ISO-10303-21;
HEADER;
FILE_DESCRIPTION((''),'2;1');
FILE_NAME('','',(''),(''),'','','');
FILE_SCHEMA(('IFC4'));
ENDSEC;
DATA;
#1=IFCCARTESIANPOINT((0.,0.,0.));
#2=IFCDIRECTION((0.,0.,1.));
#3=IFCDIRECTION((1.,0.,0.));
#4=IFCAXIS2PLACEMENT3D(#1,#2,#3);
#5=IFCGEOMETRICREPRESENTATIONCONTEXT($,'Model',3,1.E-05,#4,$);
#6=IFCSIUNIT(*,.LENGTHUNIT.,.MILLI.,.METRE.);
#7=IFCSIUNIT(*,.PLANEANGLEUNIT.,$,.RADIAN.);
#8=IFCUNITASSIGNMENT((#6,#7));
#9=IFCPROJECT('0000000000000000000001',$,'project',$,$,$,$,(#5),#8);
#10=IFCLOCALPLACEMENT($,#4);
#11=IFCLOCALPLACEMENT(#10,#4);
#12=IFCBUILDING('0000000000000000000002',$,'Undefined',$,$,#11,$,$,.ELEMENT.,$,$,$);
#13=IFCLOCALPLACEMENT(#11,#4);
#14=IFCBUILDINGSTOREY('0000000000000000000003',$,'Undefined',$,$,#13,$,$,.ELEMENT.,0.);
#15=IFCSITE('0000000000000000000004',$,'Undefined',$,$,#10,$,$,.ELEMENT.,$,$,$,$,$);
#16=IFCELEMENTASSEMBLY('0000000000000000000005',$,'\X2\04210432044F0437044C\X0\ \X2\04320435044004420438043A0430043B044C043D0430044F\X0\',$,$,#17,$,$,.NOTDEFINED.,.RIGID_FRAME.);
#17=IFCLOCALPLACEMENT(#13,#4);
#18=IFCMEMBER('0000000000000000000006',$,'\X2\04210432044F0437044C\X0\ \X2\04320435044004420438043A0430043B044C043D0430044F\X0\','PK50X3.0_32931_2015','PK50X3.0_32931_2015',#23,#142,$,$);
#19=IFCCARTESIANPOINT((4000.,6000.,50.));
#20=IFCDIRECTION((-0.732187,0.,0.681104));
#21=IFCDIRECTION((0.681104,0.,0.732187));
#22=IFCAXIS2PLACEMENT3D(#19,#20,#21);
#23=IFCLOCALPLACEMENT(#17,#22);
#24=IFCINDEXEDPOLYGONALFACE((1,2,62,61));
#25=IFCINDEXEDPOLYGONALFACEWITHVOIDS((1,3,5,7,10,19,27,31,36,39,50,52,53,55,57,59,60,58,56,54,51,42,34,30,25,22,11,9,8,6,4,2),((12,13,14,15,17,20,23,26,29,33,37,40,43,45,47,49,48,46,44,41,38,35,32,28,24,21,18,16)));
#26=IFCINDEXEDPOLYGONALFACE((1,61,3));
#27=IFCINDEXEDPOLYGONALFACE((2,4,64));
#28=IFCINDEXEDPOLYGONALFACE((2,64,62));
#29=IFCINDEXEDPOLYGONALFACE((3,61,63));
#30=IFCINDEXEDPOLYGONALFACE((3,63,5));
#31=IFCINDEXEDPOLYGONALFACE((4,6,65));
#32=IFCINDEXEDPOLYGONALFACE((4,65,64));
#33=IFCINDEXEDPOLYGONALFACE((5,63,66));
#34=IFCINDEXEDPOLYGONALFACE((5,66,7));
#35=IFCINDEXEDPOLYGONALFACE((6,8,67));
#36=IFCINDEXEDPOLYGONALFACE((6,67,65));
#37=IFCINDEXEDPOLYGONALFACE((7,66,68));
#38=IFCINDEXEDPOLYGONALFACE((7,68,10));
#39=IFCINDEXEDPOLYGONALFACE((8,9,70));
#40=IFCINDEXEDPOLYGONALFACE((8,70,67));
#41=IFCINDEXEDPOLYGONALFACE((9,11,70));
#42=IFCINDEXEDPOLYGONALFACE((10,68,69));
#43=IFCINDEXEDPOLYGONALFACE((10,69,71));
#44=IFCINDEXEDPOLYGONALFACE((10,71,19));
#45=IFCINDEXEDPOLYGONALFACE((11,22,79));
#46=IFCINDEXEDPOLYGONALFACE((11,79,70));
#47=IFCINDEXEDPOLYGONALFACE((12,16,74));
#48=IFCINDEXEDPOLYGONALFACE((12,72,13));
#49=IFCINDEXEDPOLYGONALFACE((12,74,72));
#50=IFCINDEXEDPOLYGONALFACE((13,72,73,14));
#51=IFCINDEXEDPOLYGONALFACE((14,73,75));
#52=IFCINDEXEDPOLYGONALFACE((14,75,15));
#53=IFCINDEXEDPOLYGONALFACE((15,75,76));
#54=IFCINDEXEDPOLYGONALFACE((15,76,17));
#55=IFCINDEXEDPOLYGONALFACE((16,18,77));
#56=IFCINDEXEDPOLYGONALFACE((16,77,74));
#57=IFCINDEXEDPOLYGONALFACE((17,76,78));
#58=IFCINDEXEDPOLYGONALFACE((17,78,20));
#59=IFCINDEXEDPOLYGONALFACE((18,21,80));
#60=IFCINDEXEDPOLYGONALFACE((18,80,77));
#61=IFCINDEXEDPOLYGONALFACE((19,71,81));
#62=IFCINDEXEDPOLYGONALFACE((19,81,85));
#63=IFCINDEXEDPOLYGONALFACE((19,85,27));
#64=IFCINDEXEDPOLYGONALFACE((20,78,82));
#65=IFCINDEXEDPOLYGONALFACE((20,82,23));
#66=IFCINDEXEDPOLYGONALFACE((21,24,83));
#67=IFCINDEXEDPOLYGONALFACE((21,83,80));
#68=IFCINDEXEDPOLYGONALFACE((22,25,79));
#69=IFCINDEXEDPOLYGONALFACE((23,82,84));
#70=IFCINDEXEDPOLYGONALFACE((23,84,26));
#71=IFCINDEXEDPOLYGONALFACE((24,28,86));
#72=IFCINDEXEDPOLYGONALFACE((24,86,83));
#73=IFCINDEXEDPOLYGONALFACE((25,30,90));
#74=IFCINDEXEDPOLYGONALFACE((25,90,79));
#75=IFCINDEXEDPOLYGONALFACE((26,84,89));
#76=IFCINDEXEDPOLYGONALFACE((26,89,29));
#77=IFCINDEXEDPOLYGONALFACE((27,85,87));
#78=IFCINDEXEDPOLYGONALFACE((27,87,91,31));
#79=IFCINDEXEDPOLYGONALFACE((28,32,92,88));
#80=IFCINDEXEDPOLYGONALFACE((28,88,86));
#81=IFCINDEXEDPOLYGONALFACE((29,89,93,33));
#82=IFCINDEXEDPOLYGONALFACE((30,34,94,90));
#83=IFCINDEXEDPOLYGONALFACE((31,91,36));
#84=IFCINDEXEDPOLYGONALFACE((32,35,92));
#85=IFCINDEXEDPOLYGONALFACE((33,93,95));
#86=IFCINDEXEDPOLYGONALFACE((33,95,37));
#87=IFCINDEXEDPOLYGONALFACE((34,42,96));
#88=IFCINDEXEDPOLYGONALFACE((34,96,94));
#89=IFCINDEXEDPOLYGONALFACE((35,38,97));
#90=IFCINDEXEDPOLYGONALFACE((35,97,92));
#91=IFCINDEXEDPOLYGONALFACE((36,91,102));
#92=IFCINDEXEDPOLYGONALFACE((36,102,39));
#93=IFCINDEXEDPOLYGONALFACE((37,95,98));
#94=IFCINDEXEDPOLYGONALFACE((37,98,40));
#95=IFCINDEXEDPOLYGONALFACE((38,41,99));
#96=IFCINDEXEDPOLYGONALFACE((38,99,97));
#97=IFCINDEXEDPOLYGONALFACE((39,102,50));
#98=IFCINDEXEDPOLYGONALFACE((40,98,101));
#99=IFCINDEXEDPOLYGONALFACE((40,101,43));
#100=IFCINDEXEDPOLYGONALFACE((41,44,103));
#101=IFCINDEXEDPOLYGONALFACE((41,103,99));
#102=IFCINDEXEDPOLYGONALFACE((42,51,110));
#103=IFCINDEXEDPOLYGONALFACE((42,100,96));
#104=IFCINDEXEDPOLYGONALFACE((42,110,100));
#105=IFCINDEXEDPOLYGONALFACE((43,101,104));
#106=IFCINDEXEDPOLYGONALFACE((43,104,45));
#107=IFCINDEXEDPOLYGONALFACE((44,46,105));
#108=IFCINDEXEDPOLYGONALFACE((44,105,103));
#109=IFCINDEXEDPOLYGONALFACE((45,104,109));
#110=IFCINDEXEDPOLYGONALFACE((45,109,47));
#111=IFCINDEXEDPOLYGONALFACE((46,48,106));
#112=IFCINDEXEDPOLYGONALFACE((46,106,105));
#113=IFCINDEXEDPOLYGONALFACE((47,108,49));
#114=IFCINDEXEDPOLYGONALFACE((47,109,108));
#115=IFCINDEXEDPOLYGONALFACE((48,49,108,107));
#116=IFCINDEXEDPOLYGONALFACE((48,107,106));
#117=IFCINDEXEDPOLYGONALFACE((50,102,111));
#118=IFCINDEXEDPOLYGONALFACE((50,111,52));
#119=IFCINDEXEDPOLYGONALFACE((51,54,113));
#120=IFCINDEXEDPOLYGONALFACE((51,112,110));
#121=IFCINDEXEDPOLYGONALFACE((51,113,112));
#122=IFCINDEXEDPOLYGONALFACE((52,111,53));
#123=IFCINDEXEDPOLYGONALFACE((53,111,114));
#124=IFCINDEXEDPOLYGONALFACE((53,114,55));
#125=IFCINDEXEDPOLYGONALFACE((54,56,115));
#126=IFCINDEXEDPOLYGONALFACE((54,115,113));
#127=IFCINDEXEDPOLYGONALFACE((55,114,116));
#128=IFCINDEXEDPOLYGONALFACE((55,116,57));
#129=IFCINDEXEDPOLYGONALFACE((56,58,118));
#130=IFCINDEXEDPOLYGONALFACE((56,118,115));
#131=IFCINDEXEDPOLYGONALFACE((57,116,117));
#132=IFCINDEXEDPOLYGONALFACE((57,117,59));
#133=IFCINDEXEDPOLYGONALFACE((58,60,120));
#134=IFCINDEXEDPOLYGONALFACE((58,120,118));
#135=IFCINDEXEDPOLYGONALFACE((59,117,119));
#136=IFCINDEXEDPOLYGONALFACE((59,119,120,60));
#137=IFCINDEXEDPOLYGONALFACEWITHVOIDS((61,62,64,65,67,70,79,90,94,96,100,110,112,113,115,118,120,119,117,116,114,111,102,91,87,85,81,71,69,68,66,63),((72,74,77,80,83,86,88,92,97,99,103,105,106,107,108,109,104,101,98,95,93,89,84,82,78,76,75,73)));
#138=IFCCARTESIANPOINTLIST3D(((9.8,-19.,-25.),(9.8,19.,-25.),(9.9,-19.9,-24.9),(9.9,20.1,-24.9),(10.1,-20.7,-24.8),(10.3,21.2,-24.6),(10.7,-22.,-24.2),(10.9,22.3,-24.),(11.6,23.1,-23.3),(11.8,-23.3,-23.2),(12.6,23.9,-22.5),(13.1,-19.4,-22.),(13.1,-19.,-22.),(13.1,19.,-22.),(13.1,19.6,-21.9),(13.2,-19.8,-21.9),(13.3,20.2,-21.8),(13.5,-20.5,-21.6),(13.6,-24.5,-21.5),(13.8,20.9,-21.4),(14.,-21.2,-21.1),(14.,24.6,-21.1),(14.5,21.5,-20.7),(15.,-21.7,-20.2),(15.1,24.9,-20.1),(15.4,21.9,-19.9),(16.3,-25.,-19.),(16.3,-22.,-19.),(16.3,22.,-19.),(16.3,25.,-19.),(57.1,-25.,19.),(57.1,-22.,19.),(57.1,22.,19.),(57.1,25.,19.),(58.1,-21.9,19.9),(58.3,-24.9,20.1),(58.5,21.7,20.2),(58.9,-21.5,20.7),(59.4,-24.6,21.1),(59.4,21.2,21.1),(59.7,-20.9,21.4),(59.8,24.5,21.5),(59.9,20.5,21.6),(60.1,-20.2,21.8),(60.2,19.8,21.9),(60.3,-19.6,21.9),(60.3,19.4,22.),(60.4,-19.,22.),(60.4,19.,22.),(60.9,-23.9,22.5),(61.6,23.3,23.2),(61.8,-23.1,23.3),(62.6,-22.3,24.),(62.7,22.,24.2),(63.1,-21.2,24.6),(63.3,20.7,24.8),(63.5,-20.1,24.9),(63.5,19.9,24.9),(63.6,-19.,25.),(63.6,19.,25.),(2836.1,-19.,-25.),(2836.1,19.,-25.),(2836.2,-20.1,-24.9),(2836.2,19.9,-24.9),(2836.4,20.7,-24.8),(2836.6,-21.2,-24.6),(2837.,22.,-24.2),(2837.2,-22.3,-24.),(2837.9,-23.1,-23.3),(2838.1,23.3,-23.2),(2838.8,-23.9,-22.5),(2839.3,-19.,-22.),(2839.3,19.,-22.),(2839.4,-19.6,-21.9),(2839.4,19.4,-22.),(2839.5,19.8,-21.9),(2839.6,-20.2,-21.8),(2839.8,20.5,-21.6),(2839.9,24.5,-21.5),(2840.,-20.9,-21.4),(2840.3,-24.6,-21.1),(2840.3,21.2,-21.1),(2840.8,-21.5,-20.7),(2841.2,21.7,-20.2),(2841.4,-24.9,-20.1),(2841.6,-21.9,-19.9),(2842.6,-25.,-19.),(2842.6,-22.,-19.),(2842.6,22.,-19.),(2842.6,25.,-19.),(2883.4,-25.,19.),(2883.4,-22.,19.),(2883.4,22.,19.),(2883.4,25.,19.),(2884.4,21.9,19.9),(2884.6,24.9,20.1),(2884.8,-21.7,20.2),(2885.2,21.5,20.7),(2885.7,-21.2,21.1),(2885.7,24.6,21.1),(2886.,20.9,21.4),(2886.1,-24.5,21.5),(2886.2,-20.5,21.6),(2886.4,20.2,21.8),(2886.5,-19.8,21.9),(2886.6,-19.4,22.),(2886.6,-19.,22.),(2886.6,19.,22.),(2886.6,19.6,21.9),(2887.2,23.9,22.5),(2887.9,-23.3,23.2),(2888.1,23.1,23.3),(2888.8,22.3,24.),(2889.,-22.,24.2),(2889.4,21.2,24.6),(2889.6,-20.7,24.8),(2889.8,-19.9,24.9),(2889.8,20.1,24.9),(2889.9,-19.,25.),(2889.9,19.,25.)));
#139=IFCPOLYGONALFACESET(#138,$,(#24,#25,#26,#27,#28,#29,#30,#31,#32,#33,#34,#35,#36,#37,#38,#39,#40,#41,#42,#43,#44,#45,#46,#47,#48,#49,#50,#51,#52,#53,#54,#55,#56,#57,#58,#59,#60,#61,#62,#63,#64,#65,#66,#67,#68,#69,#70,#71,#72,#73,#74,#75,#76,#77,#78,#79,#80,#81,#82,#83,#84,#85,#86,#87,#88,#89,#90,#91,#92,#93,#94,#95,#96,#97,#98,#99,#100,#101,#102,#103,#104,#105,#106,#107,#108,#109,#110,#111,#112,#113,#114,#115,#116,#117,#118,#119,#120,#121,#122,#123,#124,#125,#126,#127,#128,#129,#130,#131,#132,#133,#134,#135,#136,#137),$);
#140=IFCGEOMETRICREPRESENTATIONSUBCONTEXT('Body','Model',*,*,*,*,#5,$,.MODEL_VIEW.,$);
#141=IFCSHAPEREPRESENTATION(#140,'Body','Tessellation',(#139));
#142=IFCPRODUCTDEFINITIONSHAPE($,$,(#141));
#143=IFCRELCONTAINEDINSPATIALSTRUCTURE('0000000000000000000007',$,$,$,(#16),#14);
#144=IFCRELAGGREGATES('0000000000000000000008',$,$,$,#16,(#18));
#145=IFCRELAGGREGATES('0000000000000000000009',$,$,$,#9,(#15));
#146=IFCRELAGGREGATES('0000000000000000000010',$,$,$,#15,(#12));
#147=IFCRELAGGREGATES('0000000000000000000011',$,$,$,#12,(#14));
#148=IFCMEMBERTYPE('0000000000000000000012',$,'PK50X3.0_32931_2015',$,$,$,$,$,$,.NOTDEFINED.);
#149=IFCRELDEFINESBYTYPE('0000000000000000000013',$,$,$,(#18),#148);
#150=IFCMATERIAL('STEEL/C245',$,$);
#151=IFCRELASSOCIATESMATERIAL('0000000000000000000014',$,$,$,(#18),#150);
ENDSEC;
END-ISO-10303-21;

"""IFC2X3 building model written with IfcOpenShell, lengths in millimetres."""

from ifc_helpers import new_model, si_unit, frame, origin_with_axes, origin_2d_with_axis, place, context, subcontext, project, spatial, hollow_rectangle, extrude, clip, halfspace, material, type_object, element, aggregate, save


model = new_model("IFC2X3")

# Units and contexts
model_context = context("Model", 3, precision=1e-05, world=origin_with_axes())
body_context = subcontext(model_context, "Body", "Model", "MODEL_VIEW")
ifc_project = project(units=[si_unit("LENGTHUNIT", "METRE", prefix="MILLI"), si_unit("PLANEANGLEUNIT", "RADIAN")], contexts=[model_context])

# Site, building, storey
site_placement = place(None, origin_with_axes())
site = spatial("IfcSite", under=ifc_project, at=site_placement, Name="Undefined", CompositionType="ELEMENT")
building_placement = place(site_placement, origin_with_axes())
building = spatial("IfcBuilding", under=site, at=building_placement, Name="Undefined", CompositionType="ELEMENT")
storey_placement = place(building_placement, origin_with_axes())
storey = spatial("IfcBuildingStorey", under=building, at=storey_placement, Name="Undefined", CompositionType="ELEMENT", Elevation=0.0)

# Shared definitions
ifc_material_1 = material(Name="STEEL/C245")

# Element assembly, member
assembly_1_placement = place(storey_placement, origin_with_axes())
assembly_1 = element("IfcElementAssembly", 1, at=assembly_1_placement, inside=storey, Name="Связь вертикальная", AssemblyPlace="NOTDEFINED", PredefinedType="RIGID_FRAME")
member_type_1 = type_object("IfcMemberType", Name="PK50X3.0_32931_2015", PredefinedType="NOTDEFINED")
member_1_placement = place(assembly_1_placement, frame((4000.0, 6000.0, 50.0), z_axis=(-0.732187, 0.0, 0.681104), x_axis=(0.681104, 0.0, 0.732187)))
member_1 = element("IfcMember", 2, at=member_1_placement, type_object=member_type_1, material=ifc_material_1, Name="Связь вертикальная", Description="PK50X3.0_32931_2015", ObjectType="PK50X3.0_32931_2015", context=body_context, shape_type="Clipping", body=[
    clip(clip(extrude(hollow_rectangle(XDim=50.0, YDim=50.0, WallThickness=3.0, InnerFilletRadius=3.0, OuterFilletRadius=6.0, at=origin_2d_with_axis()), frame((2917.3, 0.0, 0.0), z_axis=(-1.0, 0.0, 0.0), x_axis=(0.0, -1.0, 0.0)), (0.0, 0.0, 1.0), 2934.9), halfspace(frame((2798.5, 0.0, -60.0), z_axis=(-0.681104, 0.0, 0.732187), x_axis=(0.0, -1.0, 0.0)), True)), halfspace(frame((-25.7, 0.0, -58.0), z_axis=(0.681104, 0.0, -0.732187), x_axis=(0.0, -1.0, 0.0)), True)),
])
aggregate(assembly_1, [member_1])

save(model, "model.ifc")
